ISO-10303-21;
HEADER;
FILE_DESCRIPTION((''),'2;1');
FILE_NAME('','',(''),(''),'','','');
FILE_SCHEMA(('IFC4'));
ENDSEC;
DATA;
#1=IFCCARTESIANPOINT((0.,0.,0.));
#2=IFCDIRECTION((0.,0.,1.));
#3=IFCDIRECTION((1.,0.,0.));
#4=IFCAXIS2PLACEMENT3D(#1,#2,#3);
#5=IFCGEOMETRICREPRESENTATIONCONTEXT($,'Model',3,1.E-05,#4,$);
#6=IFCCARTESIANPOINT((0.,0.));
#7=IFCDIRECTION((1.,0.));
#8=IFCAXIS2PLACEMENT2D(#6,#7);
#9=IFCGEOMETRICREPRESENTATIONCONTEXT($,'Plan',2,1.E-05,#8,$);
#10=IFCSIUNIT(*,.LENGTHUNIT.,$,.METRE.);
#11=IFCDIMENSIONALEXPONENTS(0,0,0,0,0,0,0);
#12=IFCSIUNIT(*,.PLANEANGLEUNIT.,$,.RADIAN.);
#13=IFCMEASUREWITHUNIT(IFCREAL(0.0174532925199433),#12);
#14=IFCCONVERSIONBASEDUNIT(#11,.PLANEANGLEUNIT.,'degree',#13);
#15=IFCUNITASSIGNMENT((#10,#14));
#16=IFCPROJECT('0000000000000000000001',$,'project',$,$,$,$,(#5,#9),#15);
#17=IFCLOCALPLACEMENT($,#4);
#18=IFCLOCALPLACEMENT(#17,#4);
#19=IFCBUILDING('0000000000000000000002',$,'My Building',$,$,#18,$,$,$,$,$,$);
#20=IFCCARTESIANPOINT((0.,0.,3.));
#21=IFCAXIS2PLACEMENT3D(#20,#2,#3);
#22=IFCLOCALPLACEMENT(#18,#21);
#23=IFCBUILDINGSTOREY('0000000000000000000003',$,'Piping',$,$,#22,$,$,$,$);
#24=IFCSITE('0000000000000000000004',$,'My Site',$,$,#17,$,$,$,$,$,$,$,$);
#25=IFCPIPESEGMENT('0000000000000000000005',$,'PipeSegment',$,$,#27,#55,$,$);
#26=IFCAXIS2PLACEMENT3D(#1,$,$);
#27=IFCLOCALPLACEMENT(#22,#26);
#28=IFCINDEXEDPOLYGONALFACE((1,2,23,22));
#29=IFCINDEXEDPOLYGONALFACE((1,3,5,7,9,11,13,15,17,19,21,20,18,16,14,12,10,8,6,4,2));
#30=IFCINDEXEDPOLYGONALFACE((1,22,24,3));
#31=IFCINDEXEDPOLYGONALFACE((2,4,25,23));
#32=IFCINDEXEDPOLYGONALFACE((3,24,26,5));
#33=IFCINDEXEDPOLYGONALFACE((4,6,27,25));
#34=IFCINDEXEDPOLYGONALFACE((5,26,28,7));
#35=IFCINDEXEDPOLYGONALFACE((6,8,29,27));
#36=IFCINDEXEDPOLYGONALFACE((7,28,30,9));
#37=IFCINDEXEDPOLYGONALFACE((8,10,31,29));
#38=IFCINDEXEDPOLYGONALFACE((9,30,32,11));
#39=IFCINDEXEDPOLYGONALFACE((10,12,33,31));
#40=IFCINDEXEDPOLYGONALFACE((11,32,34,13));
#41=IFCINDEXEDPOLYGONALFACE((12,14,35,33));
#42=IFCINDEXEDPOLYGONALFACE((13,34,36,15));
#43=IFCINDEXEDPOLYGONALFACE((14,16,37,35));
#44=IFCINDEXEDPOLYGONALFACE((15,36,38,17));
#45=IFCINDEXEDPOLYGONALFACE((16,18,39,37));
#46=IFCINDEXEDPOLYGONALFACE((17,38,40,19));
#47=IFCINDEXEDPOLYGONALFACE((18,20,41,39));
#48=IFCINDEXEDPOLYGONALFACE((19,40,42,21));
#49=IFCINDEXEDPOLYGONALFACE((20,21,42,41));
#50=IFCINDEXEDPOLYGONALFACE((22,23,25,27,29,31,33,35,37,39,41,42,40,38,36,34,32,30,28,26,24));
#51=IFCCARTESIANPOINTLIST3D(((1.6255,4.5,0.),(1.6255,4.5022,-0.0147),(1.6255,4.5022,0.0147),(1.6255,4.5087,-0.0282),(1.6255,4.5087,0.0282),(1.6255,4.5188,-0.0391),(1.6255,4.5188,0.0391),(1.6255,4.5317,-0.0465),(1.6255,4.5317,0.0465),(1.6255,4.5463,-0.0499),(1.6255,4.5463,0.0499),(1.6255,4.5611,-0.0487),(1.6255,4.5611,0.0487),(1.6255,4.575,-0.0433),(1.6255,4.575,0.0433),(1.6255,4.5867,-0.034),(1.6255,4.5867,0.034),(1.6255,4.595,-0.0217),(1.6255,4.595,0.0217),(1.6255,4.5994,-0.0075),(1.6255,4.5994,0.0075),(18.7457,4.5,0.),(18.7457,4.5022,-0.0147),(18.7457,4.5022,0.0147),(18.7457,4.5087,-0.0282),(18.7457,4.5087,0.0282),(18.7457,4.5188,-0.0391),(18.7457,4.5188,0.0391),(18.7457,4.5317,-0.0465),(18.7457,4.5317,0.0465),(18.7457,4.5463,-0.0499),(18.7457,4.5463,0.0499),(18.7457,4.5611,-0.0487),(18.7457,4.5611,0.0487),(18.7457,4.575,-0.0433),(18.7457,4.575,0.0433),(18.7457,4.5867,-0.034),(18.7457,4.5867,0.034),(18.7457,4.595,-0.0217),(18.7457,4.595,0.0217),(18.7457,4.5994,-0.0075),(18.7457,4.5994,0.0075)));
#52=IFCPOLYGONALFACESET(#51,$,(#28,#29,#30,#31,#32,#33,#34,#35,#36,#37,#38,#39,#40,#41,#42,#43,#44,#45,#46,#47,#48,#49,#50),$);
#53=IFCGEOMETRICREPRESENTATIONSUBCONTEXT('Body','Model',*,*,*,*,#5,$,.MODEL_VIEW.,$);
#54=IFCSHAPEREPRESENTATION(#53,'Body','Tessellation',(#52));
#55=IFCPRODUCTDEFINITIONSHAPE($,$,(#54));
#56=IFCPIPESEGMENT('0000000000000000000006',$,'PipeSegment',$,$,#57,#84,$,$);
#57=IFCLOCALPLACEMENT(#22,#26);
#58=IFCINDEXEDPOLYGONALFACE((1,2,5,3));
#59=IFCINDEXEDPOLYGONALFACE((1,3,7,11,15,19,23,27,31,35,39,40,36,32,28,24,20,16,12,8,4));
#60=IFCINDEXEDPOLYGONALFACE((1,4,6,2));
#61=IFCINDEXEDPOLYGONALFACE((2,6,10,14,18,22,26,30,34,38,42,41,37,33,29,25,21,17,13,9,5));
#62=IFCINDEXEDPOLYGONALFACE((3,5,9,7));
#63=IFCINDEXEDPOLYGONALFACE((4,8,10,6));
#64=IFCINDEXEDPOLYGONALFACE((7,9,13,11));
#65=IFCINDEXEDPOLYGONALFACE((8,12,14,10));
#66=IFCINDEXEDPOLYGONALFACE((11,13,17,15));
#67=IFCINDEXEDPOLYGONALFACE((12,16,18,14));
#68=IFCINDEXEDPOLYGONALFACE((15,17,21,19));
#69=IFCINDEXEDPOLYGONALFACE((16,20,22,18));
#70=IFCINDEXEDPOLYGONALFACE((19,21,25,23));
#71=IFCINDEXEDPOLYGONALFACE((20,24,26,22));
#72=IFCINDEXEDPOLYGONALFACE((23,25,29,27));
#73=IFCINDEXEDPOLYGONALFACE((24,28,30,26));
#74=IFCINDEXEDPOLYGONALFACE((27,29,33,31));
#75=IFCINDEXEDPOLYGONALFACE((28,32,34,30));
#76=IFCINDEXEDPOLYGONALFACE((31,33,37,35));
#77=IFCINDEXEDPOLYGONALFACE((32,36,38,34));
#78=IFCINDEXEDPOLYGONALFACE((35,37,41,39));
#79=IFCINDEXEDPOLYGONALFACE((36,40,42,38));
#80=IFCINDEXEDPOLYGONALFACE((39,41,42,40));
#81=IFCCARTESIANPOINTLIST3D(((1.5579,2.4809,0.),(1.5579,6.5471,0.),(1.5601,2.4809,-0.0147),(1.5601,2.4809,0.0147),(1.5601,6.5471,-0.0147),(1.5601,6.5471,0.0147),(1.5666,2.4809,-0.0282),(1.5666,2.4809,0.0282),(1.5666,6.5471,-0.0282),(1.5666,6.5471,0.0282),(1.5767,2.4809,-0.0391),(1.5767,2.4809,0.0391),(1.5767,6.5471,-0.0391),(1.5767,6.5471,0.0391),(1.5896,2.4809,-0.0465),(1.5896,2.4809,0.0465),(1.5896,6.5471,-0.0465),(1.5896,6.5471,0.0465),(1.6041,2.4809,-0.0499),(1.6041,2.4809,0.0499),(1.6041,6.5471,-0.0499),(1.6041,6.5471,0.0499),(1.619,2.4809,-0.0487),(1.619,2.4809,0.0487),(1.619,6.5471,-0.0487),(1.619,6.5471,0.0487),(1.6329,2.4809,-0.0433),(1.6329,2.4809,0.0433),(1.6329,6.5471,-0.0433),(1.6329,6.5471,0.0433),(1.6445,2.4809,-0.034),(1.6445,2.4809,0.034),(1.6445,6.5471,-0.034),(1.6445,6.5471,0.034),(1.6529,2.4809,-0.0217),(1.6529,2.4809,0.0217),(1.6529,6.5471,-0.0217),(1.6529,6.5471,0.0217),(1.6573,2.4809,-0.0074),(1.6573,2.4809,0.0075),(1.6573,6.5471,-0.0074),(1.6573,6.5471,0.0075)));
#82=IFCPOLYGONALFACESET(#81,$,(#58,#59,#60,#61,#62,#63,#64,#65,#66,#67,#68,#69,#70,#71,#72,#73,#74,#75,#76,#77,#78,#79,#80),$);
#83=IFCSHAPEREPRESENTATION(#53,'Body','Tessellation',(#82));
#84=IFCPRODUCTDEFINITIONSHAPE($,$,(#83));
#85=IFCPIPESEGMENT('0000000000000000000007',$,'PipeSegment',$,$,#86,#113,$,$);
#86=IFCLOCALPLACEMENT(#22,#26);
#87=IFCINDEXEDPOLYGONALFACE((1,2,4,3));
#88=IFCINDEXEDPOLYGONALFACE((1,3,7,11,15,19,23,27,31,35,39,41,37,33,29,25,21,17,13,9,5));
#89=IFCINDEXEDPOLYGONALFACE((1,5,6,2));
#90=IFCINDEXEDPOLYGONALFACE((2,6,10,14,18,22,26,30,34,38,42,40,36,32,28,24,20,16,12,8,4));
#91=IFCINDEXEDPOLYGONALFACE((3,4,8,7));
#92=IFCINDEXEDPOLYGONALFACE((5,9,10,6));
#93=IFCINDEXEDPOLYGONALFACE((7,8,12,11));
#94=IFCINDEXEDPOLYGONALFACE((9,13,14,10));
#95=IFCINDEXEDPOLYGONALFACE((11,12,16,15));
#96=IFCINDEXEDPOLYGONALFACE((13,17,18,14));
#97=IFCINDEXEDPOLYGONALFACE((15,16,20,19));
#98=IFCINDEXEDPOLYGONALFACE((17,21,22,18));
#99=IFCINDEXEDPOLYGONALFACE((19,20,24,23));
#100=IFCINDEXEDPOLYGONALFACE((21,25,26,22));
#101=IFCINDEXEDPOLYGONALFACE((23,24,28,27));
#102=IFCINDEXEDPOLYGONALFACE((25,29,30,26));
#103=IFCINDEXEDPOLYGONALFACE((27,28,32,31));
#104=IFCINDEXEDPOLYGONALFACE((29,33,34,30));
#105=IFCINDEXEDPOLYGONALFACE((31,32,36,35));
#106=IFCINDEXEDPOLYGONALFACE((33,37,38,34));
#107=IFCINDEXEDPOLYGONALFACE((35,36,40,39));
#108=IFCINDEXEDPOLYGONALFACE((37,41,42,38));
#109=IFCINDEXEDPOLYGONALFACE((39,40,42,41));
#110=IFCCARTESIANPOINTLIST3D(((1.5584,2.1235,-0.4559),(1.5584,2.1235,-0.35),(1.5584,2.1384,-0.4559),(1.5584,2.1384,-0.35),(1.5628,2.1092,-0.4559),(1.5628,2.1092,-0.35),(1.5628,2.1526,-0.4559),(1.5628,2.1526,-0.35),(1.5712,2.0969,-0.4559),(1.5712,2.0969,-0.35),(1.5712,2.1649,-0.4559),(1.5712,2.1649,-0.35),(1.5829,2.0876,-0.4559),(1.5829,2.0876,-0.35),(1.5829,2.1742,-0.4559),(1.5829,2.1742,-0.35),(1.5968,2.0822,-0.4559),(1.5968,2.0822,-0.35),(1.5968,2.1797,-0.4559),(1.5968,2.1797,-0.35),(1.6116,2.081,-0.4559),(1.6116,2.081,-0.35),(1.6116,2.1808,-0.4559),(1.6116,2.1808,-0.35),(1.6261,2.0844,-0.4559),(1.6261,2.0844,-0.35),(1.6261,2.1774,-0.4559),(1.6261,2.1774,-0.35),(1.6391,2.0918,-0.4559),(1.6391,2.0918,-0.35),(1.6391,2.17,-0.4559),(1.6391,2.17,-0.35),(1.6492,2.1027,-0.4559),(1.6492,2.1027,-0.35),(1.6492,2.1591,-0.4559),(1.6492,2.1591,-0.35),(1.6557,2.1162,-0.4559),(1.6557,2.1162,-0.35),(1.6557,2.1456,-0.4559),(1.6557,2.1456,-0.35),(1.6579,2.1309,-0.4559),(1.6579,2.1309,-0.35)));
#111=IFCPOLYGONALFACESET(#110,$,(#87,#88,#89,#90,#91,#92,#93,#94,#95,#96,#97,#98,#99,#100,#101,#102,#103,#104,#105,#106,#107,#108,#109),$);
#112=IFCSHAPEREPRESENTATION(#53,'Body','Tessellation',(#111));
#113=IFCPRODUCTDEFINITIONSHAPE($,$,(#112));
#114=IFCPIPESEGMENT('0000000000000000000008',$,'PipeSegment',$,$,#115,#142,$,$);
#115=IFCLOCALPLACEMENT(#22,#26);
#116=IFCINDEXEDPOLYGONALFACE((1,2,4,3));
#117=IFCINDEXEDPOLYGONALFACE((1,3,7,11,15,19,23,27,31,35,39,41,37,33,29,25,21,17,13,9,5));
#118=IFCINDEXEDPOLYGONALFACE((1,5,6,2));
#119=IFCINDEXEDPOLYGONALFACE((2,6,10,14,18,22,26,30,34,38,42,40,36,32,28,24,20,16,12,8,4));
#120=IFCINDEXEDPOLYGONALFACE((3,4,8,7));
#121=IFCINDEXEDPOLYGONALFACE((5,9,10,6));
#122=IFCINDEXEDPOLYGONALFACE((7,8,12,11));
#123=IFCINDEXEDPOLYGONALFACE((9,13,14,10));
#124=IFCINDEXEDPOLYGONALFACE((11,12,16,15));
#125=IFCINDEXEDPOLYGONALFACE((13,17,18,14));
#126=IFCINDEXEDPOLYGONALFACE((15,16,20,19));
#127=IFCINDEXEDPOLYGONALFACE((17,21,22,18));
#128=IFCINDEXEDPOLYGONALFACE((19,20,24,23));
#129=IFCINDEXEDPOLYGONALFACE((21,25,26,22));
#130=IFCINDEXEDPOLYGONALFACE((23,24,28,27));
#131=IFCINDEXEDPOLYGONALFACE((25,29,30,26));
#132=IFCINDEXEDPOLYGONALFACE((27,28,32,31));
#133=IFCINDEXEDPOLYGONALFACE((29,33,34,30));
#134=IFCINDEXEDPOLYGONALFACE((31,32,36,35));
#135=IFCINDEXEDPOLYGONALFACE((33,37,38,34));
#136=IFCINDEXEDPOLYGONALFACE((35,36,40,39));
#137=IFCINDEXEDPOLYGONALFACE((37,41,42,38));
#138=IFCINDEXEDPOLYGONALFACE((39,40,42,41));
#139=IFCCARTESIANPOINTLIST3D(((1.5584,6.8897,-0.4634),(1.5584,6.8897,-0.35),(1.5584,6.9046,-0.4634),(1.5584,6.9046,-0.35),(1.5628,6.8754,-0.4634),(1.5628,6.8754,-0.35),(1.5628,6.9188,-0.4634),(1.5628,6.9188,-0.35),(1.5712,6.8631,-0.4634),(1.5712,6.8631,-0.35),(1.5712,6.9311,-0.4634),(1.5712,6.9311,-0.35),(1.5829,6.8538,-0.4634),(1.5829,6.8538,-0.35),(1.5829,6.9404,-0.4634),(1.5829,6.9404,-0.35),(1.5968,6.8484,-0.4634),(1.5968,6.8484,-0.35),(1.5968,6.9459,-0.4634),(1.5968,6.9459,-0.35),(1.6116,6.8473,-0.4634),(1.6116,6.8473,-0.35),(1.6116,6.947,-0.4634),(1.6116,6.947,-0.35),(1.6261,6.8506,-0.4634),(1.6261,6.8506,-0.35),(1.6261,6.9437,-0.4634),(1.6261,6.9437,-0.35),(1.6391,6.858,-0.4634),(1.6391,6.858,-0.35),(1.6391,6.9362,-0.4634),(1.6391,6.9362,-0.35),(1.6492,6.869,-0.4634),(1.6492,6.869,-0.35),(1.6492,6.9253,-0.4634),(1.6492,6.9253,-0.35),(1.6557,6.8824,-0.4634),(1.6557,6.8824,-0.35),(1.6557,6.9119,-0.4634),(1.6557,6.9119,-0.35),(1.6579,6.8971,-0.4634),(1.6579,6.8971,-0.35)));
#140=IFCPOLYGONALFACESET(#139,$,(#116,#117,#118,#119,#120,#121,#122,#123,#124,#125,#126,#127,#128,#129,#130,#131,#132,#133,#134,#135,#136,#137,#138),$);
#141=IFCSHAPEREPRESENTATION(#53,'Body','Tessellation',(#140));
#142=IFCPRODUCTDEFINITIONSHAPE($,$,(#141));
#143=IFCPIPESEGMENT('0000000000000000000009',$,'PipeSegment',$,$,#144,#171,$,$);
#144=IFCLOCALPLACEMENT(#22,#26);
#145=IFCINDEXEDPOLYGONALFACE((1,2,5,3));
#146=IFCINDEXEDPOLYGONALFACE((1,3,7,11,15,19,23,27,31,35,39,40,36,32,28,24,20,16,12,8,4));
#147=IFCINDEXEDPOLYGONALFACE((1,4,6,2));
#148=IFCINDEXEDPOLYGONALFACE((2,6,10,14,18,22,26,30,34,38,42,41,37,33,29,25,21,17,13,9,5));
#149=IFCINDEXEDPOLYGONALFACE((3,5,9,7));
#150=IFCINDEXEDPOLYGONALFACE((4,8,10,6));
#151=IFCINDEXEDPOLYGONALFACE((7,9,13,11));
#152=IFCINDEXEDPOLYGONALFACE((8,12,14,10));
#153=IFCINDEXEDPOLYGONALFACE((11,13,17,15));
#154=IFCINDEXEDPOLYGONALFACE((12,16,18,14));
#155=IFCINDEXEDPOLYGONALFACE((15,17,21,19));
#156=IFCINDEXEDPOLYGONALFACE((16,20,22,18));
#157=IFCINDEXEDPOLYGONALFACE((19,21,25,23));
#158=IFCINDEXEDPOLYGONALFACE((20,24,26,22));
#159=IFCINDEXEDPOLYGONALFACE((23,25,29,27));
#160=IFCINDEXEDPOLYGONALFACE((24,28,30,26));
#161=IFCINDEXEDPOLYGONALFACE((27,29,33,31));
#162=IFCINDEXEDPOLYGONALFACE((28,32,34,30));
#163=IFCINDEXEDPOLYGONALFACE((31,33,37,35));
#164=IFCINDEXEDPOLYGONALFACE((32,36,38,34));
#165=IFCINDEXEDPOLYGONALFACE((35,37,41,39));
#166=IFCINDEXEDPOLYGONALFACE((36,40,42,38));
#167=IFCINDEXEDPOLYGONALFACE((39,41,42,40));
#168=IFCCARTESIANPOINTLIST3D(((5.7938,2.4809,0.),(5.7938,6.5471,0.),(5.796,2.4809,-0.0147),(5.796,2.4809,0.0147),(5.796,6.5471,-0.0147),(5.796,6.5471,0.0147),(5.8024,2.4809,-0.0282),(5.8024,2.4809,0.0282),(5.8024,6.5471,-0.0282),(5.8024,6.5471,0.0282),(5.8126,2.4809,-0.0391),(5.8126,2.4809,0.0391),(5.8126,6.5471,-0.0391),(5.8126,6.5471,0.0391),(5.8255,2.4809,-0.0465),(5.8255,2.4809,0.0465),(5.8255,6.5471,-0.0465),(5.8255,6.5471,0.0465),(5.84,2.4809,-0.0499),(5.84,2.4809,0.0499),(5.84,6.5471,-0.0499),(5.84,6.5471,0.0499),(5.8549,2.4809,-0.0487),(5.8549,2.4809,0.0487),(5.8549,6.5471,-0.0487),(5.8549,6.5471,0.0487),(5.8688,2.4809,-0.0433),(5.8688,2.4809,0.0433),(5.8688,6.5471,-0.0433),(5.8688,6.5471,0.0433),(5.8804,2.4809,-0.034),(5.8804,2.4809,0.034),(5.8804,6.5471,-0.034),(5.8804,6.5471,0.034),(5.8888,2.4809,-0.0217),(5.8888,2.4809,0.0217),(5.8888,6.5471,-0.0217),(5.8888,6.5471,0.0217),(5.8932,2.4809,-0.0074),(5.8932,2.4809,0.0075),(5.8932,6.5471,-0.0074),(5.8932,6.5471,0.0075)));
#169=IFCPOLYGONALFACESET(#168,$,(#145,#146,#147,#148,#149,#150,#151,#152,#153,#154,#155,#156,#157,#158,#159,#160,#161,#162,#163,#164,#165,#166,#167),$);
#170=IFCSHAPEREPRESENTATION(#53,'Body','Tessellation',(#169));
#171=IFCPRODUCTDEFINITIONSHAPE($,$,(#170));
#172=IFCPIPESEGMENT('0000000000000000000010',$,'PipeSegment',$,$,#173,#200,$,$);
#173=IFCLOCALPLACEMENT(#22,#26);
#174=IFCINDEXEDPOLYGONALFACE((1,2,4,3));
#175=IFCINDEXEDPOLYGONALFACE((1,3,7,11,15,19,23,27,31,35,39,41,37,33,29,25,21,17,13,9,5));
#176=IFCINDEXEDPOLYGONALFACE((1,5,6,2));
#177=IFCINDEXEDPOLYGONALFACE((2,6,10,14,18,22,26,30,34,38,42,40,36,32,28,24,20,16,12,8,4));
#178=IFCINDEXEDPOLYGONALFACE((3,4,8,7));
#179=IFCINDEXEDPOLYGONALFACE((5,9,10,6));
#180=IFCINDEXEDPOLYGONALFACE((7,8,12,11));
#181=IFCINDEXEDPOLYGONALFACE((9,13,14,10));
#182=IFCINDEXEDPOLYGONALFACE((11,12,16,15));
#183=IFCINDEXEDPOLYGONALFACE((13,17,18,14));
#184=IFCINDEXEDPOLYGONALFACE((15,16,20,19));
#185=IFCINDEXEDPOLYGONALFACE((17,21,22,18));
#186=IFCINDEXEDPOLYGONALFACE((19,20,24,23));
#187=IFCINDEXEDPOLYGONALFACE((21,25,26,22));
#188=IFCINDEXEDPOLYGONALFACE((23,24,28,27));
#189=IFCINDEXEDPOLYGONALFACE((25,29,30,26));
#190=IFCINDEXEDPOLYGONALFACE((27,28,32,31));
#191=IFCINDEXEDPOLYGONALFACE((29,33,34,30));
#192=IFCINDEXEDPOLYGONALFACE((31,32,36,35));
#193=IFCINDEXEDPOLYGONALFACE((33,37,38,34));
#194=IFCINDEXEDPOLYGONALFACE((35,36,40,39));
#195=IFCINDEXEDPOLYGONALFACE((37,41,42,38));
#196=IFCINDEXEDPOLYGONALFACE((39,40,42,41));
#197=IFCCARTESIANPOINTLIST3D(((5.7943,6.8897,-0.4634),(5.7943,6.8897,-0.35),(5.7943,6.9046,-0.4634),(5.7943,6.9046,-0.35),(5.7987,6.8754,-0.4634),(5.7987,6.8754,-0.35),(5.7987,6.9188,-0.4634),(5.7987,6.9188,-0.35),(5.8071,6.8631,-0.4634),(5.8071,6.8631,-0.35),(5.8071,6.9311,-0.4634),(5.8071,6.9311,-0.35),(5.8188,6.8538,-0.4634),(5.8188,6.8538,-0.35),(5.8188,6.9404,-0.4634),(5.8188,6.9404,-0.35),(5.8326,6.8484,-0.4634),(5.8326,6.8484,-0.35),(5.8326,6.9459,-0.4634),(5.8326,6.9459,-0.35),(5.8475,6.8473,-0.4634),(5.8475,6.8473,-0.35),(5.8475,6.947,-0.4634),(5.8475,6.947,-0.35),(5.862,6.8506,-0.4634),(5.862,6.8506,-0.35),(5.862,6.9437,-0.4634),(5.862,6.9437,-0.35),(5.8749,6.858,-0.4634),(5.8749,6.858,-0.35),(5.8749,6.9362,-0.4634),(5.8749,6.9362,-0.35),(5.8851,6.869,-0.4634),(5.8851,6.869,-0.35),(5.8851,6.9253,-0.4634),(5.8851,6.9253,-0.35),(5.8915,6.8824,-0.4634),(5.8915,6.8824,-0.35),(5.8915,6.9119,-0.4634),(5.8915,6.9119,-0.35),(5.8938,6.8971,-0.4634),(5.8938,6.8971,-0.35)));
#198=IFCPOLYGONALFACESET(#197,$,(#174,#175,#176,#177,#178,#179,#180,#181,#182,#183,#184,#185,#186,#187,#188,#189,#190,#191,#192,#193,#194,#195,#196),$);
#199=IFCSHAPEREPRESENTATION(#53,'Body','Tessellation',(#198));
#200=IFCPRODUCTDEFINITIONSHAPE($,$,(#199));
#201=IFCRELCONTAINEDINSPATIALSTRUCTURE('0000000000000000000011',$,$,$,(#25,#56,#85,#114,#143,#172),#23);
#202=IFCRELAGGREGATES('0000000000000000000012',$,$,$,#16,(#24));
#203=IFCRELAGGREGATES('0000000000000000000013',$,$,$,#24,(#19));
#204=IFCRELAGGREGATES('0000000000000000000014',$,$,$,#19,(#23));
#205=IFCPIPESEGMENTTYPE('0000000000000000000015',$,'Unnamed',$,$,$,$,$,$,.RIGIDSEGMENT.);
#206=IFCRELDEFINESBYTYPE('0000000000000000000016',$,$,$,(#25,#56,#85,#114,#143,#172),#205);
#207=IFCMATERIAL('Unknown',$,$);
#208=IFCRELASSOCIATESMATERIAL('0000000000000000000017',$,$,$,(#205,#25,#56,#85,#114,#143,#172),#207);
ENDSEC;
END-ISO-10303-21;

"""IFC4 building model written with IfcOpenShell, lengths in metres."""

from ifc_helpers import new_model, entity, si_unit, converted_unit, frame, origin_with_axes, origin_2d_with_axis, place, context, subcontext, project, spatial, circle, extrude, material, material_profile, profile_set, profile_usage, type_object, element, save


model = new_model("IFC4")

# Units and contexts
model_context = context("Model", 3, precision=1e-05, world=origin_with_axes())
plan_context = context("Plan", 2, precision=1e-05, world=origin_2d_with_axis())
body_context = subcontext(model_context, "Body", "Model", "MODEL_VIEW")
ifc_project = project(units=[si_unit("LENGTHUNIT", "METRE"), converted_unit("PLANEANGLEUNIT", "degree", entity("IfcReal", 0.0174532925199433), si_unit("PLANEANGLEUNIT", "RADIAN"), dimensions=[0, 0, 0, 0, 0, 0, 0])], contexts=[model_context, plan_context])

# Site, building, storey
site_placement = place(None, origin_with_axes())
site = spatial("IfcSite", under=ifc_project, at=site_placement, Name="My Site")
building_placement = place(site_placement, origin_with_axes())
building = spatial("IfcBuilding", under=site, at=building_placement, Name="My Building")
storey_placement = place(building_placement, frame((0.0, 0.0, 3.0), z_axis=(0.0, 0.0, 1.0), x_axis=(1.0, 0.0, 0.0)))
storey = spatial("IfcBuildingStorey", under=building, at=storey_placement, Name="Piping")

# Pipe segments
ifc_material = material(Name="Unknown")
ifc_material_profile = material_profile(ifc_material, circle(Radius=0.05))
ifc_profile_set = profile_set([ifc_material_profile])
ifc_profile_usage_1 = profile_usage(ifc_profile_set, cardinal=5)
pipe_segment_type = type_object("IfcPipeSegmentType", Name="Unnamed", PredefinedType="RIGIDSEGMENT", material=ifc_profile_set)
pipe_segment_1_placement = place(storey_placement, frame((18.7457, 4.55, 0.0), z_axis=(-1.0, 0.0, 0.0), x_axis=(0.0, -1.0, 0.0)))
element("IfcPipeSegment", 1, at=pipe_segment_1_placement, inside=storey, type_object=pipe_segment_type, material=ifc_profile_usage_1, Name="PipeSegment", context=body_context, shape_type="SweptSolid", body=[
    extrude(circle(Radius=0.05), origin_with_axes(), (0.0, 0.0, 1.0), 17.1202),
])
ifc_profile_usage_2 = profile_usage(ifc_profile_set, cardinal=5)
pipe_segment_2_placement = place(storey_placement, frame((1.6079, 2.4809, 0.0), z_axis=(0.0, 1.0, 0.0), x_axis=(-1.0, 0.0, 0.0)))
element("IfcPipeSegment", 2, at=pipe_segment_2_placement, inside=storey, type_object=pipe_segment_type, material=ifc_profile_usage_2, Name="PipeSegment", context=body_context, shape_type="SweptSolid", body=[
    extrude(circle(Radius=0.05), origin_with_axes(), (0.0, 0.0, 1.0), 4.0662),
])
ifc_profile_usage_3 = profile_usage(ifc_profile_set, cardinal=5)
pipe_segment_3_placement = place(storey_placement, frame((1.6079, 2.1309, -0.35), z_axis=(0.0, 0.0, -1.0), x_axis=(1.0, 0.0, 0.0)))
element("IfcPipeSegment", 3, at=pipe_segment_3_placement, inside=storey, type_object=pipe_segment_type, material=ifc_profile_usage_3, Name="PipeSegment", context=body_context, shape_type="SweptSolid", body=[
    extrude(circle(Radius=0.05), origin_with_axes(), (0.0, 0.0, 1.0), 0.1059),
])
ifc_profile_usage_4 = profile_usage(ifc_profile_set, cardinal=5)
pipe_segment_4_placement = place(storey_placement, frame((1.6079, 6.8971, -0.35), z_axis=(0.0, 0.0, -1.0), x_axis=(1.0, 0.0, 0.0)))
element("IfcPipeSegment", 4, at=pipe_segment_4_placement, inside=storey, type_object=pipe_segment_type, material=ifc_profile_usage_4, Name="PipeSegment", context=body_context, shape_type="SweptSolid", body=[
    extrude(circle(Radius=0.05), origin_with_axes(), (0.0, 0.0, 1.0), 0.1134),
])
ifc_profile_usage_5 = profile_usage(ifc_profile_set, cardinal=5)
pipe_segment_5_placement = place(storey_placement, frame((5.8438, 2.4809, 0.0), z_axis=(0.0, 1.0, 0.0), x_axis=(-1.0, 0.0, 0.0)))
element("IfcPipeSegment", 5, at=pipe_segment_5_placement, inside=storey, type_object=pipe_segment_type, material=ifc_profile_usage_5, Name="PipeSegment", context=body_context, shape_type="SweptSolid", body=[
    extrude(circle(Radius=0.05), origin_with_axes(), (0.0, 0.0, 1.0), 4.0662),
])
ifc_profile_usage_6 = profile_usage(ifc_profile_set, cardinal=5)
pipe_segment_6_placement = place(storey_placement, frame((5.8438, 6.8971, -0.35), z_axis=(0.0, 0.0, -1.0), x_axis=(1.0, 0.0, 0.0)))
element("IfcPipeSegment", 6, at=pipe_segment_6_placement, inside=storey, type_object=pipe_segment_type, material=ifc_profile_usage_6, Name="PipeSegment", context=body_context, shape_type="SweptSolid", body=[
    extrude(circle(Radius=0.05), origin_with_axes(), (0.0, 0.0, 1.0), 0.1134),
])

save(model, "model.ifc")
